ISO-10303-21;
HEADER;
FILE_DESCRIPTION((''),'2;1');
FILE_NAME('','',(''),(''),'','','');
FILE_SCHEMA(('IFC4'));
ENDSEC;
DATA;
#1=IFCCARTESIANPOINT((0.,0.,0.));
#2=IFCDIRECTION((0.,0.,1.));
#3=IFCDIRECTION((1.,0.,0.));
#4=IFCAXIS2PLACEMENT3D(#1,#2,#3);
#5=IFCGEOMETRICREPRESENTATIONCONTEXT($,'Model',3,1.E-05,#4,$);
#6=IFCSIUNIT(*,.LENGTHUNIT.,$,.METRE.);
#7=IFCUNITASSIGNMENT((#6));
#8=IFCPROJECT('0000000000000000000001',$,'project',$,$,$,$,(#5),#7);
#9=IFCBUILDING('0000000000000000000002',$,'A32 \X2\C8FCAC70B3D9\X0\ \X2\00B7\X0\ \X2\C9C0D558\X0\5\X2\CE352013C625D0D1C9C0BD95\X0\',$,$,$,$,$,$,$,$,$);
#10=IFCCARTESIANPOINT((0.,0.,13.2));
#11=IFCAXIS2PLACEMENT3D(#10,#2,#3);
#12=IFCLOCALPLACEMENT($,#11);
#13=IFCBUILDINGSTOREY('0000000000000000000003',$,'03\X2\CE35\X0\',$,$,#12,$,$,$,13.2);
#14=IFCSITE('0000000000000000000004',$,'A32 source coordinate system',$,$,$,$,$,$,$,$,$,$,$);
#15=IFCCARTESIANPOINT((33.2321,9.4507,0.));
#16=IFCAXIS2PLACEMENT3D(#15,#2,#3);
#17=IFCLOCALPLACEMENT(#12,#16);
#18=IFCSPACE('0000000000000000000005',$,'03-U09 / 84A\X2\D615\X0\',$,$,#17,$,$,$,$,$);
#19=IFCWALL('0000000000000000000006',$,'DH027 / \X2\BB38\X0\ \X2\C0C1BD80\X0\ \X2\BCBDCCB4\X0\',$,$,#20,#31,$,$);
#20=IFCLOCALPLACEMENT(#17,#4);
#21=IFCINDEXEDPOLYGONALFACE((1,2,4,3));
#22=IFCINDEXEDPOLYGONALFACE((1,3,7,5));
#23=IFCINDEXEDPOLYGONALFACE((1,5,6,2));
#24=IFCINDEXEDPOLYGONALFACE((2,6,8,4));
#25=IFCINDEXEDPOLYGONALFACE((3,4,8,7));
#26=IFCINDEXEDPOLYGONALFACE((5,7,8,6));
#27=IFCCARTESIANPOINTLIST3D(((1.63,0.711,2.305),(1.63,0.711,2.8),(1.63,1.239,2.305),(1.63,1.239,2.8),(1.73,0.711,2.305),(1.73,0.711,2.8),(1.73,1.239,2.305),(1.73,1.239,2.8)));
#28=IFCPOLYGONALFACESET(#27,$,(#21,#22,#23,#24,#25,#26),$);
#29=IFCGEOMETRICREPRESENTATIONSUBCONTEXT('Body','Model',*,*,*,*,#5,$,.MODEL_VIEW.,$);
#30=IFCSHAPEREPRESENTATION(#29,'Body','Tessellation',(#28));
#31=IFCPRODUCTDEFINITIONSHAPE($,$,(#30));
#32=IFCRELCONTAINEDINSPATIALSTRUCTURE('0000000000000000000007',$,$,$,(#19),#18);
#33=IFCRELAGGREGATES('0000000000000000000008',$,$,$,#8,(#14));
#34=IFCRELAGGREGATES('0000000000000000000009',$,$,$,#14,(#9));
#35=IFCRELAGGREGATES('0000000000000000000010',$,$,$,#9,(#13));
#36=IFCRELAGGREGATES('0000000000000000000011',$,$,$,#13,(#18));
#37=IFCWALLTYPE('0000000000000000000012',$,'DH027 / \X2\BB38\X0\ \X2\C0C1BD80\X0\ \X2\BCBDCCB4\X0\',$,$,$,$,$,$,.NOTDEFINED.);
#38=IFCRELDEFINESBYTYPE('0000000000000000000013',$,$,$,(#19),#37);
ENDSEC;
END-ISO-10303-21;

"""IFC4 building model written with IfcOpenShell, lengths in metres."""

from ifc_helpers import new_model, si_unit, frame, origin, origin_with_axes, place, context, subcontext, project, spatial, polyline, outline, extrude, source, transform, mapped, type_object, type_shapes, element, save


model = new_model("IFC4")

# Units and contexts
model_context = context("Model", 3, precision=1e-05, world=origin_with_axes())
body_context = subcontext(model_context, "Body", "Model", "MODEL_VIEW")
ifc_project = project(units=[si_unit("LENGTHUNIT", "METRE")], contexts=[model_context])

# Site, building, storey, space
site = spatial("IfcSite", under=ifc_project, Name="A32 source coordinate system")
building = spatial("IfcBuilding", under=site, Name="A32 주거동 · 지하5층–옥탑지붕")
storey_placement = place(None, frame((0.0, 0.0, 13.2), z_axis=(0.0, 0.0, 1.0), x_axis=(1.0, 0.0, 0.0)))
storey = spatial("IfcBuildingStorey", under=building, at=storey_placement, Name="03층", Elevation=13.2)
space_placement = place(storey_placement, frame((33.2321, 9.4507, 0.0), z_axis=(0.0, 0.0, 1.0), x_axis=(1.0, 0.0, 0.0)))
space = spatial("IfcSpace", under=storey, at=space_placement, Name="03-U09 / 84A형")

# Wall
wall_type_1 = type_object("IfcWallType", Name="DH027 / 문 상부 벽체", PredefinedType="NOTDEFINED")
shared_shape_1 = source(origin(), body_context, "Body", "SweptSolid", [
    extrude(outline(polyline([(1.63, 1.239), (1.73, 1.239), (1.73, 0.711), (1.63, 0.711), (1.63, 1.239)])), frame((0.0, 0.0, 2.305)), (0.0, 0.0, 1.0), 0.495),
])
type_shapes(wall_type_1, [shared_shape_1])
wall_1_placement = place(space_placement, origin_with_axes())
element("IfcWall", 1, at=wall_1_placement, inside=space, type_object=wall_type_1, Name="DH027 / 문 상부 벽체", context=body_context, shape_type="MappedRepresentation", body=[
    mapped(shared_shape_1, transform((0.0, 0.0, 0.0), scale=1.0)),
])

save(model, "model.ifc")
